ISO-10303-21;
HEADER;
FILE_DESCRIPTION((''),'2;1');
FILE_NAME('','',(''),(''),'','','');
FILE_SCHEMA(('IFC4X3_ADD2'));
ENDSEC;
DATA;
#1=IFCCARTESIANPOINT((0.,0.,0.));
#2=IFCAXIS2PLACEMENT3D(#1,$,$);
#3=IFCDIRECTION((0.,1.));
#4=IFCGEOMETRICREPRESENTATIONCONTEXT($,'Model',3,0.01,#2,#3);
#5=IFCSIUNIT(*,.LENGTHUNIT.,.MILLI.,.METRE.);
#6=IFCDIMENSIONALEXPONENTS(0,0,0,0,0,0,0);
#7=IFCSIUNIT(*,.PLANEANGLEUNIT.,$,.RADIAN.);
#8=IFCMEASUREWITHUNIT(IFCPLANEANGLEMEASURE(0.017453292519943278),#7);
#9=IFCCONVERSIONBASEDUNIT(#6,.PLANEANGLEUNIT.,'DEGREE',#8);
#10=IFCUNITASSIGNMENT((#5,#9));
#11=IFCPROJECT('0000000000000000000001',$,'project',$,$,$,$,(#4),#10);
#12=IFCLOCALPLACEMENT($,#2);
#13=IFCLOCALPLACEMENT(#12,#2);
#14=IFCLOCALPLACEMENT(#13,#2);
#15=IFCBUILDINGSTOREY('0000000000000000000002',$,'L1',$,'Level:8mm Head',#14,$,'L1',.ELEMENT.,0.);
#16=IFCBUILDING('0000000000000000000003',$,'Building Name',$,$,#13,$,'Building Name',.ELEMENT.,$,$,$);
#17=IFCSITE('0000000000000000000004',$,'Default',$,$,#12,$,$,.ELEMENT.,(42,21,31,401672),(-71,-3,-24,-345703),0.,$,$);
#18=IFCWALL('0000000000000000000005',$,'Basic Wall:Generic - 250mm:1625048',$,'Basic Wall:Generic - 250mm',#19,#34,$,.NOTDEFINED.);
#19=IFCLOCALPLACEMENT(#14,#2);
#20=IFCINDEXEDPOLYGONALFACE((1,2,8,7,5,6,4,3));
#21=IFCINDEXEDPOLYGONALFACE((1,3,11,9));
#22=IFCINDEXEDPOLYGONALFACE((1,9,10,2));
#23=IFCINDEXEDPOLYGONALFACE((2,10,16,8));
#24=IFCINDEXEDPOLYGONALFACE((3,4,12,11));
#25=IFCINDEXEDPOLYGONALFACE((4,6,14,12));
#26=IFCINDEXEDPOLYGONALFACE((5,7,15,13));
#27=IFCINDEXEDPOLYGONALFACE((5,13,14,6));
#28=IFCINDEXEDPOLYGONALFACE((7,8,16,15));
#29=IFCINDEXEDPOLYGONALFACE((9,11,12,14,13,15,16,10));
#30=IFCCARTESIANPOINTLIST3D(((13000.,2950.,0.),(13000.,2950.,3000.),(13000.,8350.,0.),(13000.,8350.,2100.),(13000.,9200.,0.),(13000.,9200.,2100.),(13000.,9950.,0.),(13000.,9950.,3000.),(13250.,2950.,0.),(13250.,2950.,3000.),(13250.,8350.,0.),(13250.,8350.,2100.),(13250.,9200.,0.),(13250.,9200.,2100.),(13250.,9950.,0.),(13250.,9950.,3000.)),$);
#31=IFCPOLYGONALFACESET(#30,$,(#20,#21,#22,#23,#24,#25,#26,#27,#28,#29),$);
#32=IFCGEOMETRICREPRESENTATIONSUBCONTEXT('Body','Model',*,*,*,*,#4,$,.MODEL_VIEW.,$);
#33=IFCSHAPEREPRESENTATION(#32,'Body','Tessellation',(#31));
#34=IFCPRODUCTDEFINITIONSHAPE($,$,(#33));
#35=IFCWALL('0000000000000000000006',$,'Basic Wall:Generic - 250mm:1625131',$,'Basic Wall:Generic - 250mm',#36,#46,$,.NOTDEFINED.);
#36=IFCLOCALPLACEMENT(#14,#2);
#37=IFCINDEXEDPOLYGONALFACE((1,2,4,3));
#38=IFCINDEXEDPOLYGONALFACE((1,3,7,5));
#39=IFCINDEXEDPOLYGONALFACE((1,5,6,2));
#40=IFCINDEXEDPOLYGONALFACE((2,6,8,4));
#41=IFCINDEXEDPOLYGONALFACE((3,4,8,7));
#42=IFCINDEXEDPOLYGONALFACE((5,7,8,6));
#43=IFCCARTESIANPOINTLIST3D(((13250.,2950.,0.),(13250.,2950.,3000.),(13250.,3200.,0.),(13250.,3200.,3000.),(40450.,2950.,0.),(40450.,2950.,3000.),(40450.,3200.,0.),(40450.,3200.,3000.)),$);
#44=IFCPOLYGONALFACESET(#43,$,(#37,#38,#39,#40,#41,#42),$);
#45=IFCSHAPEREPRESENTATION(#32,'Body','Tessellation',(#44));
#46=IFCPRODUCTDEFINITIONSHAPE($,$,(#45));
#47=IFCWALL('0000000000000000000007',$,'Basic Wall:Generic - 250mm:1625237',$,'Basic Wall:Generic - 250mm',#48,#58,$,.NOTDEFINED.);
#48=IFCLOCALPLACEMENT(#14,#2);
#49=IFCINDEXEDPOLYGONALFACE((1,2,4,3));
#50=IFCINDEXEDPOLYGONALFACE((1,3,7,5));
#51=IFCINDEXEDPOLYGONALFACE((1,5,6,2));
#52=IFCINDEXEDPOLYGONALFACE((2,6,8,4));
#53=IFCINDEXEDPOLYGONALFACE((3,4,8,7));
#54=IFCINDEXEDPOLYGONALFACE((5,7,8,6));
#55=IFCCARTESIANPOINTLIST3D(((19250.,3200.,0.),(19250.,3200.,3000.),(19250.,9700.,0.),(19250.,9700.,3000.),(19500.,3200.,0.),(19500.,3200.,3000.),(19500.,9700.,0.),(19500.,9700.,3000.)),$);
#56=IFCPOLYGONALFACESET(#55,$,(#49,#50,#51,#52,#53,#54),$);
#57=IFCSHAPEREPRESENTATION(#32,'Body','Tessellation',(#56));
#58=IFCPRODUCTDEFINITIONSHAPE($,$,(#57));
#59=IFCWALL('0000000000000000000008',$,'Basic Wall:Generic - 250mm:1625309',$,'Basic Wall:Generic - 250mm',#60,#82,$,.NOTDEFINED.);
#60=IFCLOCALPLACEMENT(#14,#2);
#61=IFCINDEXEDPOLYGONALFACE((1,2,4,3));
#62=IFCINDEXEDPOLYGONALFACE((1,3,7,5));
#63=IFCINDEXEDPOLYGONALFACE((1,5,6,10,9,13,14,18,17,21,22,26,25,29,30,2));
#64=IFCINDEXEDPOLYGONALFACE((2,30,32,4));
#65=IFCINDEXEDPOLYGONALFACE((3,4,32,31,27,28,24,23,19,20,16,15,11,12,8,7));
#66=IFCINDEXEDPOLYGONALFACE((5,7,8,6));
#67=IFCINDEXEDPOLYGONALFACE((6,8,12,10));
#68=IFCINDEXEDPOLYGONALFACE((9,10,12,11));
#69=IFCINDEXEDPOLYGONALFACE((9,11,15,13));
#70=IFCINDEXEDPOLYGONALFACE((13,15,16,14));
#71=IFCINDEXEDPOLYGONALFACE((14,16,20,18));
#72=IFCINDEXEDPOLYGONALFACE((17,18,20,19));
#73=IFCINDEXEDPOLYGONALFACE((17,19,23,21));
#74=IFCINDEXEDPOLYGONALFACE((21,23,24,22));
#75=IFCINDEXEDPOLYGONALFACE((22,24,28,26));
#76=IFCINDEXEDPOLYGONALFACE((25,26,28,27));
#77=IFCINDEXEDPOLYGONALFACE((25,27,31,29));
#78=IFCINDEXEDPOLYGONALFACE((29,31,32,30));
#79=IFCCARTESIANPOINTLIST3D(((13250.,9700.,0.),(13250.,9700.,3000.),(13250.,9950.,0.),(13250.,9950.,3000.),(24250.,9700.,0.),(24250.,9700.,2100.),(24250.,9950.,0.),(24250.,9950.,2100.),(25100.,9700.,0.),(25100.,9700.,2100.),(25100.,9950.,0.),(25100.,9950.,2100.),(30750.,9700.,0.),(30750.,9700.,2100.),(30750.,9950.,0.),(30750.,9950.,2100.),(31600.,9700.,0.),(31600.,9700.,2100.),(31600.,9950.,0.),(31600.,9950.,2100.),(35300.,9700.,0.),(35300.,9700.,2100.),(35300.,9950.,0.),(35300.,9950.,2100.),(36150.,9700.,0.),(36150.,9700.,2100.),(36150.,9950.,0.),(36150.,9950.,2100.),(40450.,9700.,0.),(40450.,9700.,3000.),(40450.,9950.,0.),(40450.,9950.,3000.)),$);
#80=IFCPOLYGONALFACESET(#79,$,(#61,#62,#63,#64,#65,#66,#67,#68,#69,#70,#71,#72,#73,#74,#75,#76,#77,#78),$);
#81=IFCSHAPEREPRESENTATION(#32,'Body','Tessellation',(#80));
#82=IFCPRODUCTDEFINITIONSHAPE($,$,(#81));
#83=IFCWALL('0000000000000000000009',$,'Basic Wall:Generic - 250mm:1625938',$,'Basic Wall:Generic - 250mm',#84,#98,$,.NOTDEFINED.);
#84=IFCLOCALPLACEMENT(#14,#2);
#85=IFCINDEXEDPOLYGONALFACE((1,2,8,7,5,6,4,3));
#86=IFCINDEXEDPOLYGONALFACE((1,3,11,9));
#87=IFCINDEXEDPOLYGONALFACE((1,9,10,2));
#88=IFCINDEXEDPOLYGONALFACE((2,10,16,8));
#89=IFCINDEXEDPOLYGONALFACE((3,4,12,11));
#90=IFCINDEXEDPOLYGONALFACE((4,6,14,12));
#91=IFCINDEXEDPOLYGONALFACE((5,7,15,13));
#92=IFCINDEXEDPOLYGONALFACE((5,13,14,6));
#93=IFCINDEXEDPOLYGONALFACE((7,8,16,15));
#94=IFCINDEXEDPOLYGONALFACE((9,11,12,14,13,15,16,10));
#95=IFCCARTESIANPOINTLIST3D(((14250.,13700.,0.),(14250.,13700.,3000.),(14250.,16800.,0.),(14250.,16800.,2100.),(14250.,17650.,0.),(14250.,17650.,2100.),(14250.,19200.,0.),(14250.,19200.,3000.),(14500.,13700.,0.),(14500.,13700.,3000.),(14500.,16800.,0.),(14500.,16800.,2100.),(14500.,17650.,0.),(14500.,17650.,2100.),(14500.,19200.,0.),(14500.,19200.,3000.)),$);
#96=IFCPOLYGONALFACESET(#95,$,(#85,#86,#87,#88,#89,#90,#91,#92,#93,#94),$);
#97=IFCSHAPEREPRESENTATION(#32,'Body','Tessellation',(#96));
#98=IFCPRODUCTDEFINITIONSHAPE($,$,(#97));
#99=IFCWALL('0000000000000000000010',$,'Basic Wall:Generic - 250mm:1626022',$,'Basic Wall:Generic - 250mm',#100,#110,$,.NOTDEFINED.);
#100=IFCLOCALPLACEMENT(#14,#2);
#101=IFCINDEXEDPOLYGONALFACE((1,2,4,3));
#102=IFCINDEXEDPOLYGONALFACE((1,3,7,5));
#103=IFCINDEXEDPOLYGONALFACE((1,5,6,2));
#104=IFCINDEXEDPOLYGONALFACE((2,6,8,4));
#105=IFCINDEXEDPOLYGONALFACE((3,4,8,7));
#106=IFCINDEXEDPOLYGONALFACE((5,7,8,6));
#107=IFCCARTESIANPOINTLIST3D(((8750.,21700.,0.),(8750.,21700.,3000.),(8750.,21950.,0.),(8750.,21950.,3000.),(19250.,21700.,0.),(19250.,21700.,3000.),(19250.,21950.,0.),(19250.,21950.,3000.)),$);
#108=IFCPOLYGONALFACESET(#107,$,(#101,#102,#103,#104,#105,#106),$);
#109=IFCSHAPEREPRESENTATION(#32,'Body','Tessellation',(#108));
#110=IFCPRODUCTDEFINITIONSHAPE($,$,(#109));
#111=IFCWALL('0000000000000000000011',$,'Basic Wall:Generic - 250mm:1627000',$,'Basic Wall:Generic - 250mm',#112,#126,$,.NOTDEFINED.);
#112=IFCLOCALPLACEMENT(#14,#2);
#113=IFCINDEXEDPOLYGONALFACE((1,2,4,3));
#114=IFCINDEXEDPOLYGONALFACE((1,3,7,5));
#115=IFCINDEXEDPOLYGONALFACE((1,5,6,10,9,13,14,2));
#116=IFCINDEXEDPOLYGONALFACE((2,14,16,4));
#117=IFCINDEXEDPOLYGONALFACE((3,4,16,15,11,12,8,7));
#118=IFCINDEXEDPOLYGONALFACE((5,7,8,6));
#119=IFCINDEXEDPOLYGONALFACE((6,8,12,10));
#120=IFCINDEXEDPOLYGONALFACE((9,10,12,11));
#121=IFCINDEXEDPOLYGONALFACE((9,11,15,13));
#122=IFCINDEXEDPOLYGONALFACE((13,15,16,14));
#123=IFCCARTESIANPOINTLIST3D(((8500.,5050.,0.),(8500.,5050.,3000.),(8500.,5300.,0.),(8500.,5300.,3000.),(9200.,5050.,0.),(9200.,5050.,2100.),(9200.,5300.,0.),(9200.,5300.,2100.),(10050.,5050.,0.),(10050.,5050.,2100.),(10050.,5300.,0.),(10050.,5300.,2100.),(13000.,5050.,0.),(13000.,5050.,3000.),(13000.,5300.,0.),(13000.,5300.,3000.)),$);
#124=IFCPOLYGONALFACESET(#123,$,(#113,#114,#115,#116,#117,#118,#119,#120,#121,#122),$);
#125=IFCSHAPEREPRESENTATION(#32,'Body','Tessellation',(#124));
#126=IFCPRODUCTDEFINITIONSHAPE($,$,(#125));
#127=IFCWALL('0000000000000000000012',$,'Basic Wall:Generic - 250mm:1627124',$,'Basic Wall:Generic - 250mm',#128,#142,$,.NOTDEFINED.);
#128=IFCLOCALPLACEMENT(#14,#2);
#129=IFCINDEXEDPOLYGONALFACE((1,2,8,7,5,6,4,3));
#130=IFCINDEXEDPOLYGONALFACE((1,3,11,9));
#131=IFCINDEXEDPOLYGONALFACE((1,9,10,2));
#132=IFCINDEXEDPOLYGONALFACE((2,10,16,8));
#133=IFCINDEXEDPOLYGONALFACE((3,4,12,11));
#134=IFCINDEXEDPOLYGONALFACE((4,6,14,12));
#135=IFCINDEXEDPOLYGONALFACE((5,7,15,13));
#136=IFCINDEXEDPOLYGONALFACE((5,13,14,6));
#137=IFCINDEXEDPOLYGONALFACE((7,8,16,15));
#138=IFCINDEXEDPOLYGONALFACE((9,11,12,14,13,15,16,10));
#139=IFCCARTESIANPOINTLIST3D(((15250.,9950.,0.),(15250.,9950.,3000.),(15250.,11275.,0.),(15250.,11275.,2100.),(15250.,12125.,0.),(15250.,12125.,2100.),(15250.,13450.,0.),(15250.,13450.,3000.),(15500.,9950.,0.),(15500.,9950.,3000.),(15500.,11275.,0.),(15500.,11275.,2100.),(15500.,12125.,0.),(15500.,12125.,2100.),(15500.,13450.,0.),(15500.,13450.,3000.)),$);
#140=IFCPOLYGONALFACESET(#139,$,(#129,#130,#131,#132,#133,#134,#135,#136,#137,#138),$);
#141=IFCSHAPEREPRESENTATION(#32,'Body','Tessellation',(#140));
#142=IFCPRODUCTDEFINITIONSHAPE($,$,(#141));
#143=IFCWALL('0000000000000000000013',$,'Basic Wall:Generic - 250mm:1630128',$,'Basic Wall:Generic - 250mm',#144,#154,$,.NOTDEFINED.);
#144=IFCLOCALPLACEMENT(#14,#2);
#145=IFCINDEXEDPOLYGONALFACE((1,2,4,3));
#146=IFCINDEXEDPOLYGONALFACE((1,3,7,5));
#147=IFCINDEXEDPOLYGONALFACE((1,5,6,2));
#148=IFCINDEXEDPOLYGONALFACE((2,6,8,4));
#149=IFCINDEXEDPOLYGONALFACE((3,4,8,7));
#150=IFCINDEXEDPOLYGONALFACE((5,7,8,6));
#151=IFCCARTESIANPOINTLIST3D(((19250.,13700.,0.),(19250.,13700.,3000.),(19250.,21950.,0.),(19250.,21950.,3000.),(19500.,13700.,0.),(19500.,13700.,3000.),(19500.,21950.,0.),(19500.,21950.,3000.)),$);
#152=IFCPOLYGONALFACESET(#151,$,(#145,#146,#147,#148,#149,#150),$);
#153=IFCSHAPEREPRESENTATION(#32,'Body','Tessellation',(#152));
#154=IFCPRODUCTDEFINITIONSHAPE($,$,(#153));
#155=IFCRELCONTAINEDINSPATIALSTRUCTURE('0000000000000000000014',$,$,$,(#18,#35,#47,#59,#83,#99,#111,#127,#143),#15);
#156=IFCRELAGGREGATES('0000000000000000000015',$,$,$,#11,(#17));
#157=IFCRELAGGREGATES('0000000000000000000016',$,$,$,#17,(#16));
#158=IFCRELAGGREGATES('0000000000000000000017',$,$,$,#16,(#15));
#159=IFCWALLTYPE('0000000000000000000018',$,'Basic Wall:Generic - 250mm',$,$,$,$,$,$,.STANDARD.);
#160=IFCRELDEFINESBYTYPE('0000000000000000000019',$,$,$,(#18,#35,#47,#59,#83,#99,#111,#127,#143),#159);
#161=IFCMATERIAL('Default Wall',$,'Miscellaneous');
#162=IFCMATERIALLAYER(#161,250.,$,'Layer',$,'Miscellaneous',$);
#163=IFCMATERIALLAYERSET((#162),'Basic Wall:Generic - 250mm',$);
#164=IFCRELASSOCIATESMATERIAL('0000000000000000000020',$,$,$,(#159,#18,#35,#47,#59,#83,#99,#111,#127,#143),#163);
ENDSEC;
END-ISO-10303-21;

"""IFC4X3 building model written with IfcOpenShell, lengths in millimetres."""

from ifc_helpers import new_model, entity, si_unit, converted_unit, direction, frame, frame_2d, origin, place, context, subcontext, project, spatial, rectangle, extrude, material, layer, layer_set, type_object, element, save


model = new_model("IFC4X3")

# Units and contexts
model_context = context("Model", 3, precision=0.01, world=origin(), true_north=direction((0.0, 1.0)))
body_context = subcontext(model_context, "Body", "Model", "MODEL_VIEW")
ifc_project = project(units=[si_unit("LENGTHUNIT", "METRE", prefix="MILLI"), converted_unit("PLANEANGLEUNIT", "DEGREE", entity("IfcPlaneAngleMeasure", 0.017453292519943278), si_unit("PLANEANGLEUNIT", "RADIAN"), dimensions=[0, 0, 0, 0, 0, 0, 0])], contexts=[model_context])

# Site, building, storey
site_placement = place(None, origin())
site = spatial("IfcSite", under=ifc_project, at=site_placement, Name="Default", CompositionType="ELEMENT", RefLatitude=(42, 21, 31, 401672), RefLongitude=(-71, -3, -24, -345703), RefElevation=0.0)
building_placement = place(site_placement, origin())
building = spatial("IfcBuilding", under=site, at=building_placement, Name="Building Name", LongName="Building Name", CompositionType="ELEMENT")
storey_placement = place(building_placement, origin())
storey = spatial("IfcBuildingStorey", under=building, at=storey_placement, Name="L1", ObjectType="Level:8mm Head", LongName="L1", CompositionType="ELEMENT", Elevation=0.0)

# Wall, opening
ifc_material = material(Name="Default Wall", Category="Miscellaneous")
ifc_layer = layer(ifc_material, 250.0, Name="Layer", Category="Miscellaneous")
ifc_layer_set = layer_set([ifc_layer], Name="Basic Wall:Generic - 250mm")
wall_type = type_object("IfcWallType", Name="Basic Wall:Generic - 250mm", PredefinedType="STANDARD", material=ifc_layer_set)
wall_1_placement = place(storey_placement, frame((13125.0, 9950.0, 0.0), z_axis=(0.0, 0.0, 1.0), x_axis=(0.0, -1.0, 0.0)))
wall_1 = element("IfcWall", 1, at=wall_1_placement, inside=storey, type_object=wall_type, material=ifc_layer_set, Name="Basic Wall:Generic - 250mm:1625048", ObjectType="Basic Wall:Generic - 250mm", PredefinedType="NOTDEFINED", context=body_context, shape_type="SweptSolid", body=[
    extrude(rectangle(XDim=7000.0, YDim=250.0, at=frame_2d((3500.0, 0.0), x_axis=(-1.0, 0.0))), origin(), (0.0, 0.0, 1.0), 3000.0),
])
opening_1_placement = place(wall_1_placement, frame((750.0, -125.0, 0.0)))
element("IfcOpeningElement", 2, at=opening_1_placement, cuts=wall_1, PredefinedType="OPENING", context=body_context, shape_type="SweptSolid", body=[
    extrude(rectangle(XDim=2100.0, YDim=850.0, at=frame_2d((1050.0, 425.0), x_axis=(1.0, 0.0))), frame((0.0, 0.0, 0.0), z_axis=(0.0, 1.0, 0.0), x_axis=(0.0, 0.0, 1.0)), (0.0, 0.0, 1.0), 250.0),
])

# Walls
wall_2_placement = place(storey_placement, frame((13250.0, 3075.0, 0.0)))
element("IfcWall", 3, at=wall_2_placement, inside=storey, type_object=wall_type, material=ifc_layer_set, Name="Basic Wall:Generic - 250mm:1625131", ObjectType="Basic Wall:Generic - 250mm", PredefinedType="NOTDEFINED", context=body_context, shape_type="SweptSolid", body=[
    extrude(rectangle(XDim=27200.0, YDim=250.0, at=frame_2d((13600.0, 0.0), x_axis=(-1.0, 0.0))), origin(), (0.0, 0.0, 1.0), 3000.0),
])
wall_3_placement = place(storey_placement, frame((19375.0, 3200.0, 0.0), z_axis=(0.0, 0.0, 1.0), x_axis=(0.0, 1.0, 0.0)))
element("IfcWall", 4, at=wall_3_placement, inside=storey, type_object=wall_type, material=ifc_layer_set, Name="Basic Wall:Generic - 250mm:1625237", ObjectType="Basic Wall:Generic - 250mm", PredefinedType="NOTDEFINED", context=body_context, shape_type="SweptSolid", body=[
    extrude(rectangle(XDim=6500.0, YDim=250.0, at=frame_2d((3250.0, 0.0), x_axis=(-1.0, 0.0))), origin(), (0.0, 0.0, 1.0), 3000.0),
])

# Wall, openings
wall_4_placement = place(storey_placement, frame((40450.0, 9825.0, 0.0), z_axis=(0.0, 0.0, 1.0), x_axis=(-1.0, 0.0, 0.0)))
wall_4 = element("IfcWall", 5, at=wall_4_placement, inside=storey, type_object=wall_type, material=ifc_layer_set, Name="Basic Wall:Generic - 250mm:1625309", ObjectType="Basic Wall:Generic - 250mm", PredefinedType="NOTDEFINED", context=body_context, shape_type="SweptSolid", body=[
    extrude(rectangle(XDim=27200.0, YDim=250.0, at=frame_2d((13600.0, 0.0), x_axis=(1.0, 0.0))), origin(), (0.0, 0.0, 1.0), 3000.0),
])
opening_2_placement = place(wall_4_placement, frame((15350.0, -125.0, 0.0)))
element("IfcOpeningElement", 6, at=opening_2_placement, cuts=wall_4, PredefinedType="OPENING", context=body_context, shape_type="SweptSolid", body=[
    extrude(rectangle(XDim=2100.0, YDim=850.0, at=frame_2d((1050.0, 425.0), x_axis=(1.0, 0.0))), frame((0.0, 0.0, 0.0), z_axis=(0.0, 1.0, 0.0), x_axis=(0.0, 0.0, 1.0)), (0.0, 0.0, 1.0), 250.0),
])
opening_3_placement = place(wall_4_placement, frame((8850.0, -125.0, 0.0)))
element("IfcOpeningElement", 7, at=opening_3_placement, cuts=wall_4, PredefinedType="OPENING", context=body_context, shape_type="SweptSolid", body=[
    extrude(rectangle(XDim=2100.0, YDim=850.0, at=frame_2d((1050.0, 425.0), x_axis=(1.0, 0.0))), frame((0.0, 0.0, 0.0), z_axis=(0.0, 1.0, 0.0), x_axis=(0.0, 0.0, 1.0)), (0.0, 0.0, 1.0), 250.0),
])
opening_4_placement = place(wall_4_placement, frame((4300.0, -125.0, 0.0)))
element("IfcOpeningElement", 8, at=opening_4_placement, cuts=wall_4, PredefinedType="OPENING", context=body_context, shape_type="SweptSolid", body=[
    extrude(rectangle(XDim=2100.0, YDim=850.0, at=frame_2d((1050.0, 425.0), x_axis=(1.0, 0.0))), frame((0.0, 0.0, 0.0), z_axis=(0.0, 1.0, 0.0), x_axis=(0.0, 0.0, 1.0)), (0.0, 0.0, 1.0), 250.0),
])

# Wall, opening
wall_5_placement = place(storey_placement, frame((14375.0, 13700.0, 0.0), z_axis=(0.0, 0.0, 1.0), x_axis=(0.0, 1.0, 0.0)))
wall_5 = element("IfcWall", 9, at=wall_5_placement, inside=storey, type_object=wall_type, material=ifc_layer_set, Name="Basic Wall:Generic - 250mm:1625938", ObjectType="Basic Wall:Generic - 250mm", PredefinedType="NOTDEFINED", context=body_context, shape_type="SweptSolid", body=[
    extrude(rectangle(XDim=5500.0, YDim=250.0, at=frame_2d((2750.0, 0.0), x_axis=(1.0, 0.0))), origin(), (0.0, 0.0, 1.0), 3000.0),
])
opening_5_placement = place(wall_5_placement, frame((3950.0, 125.0, 0.0)))
element("IfcOpeningElement", 10, at=opening_5_placement, cuts=wall_5, PredefinedType="OPENING", context=body_context, shape_type="SweptSolid", body=[
    extrude(rectangle(XDim=2100.0, YDim=850.0, at=frame_2d((1050.0, 425.0), x_axis=(1.0, 0.0))), frame((0.0, 0.0, 0.0), z_axis=(0.0, -1.0, 0.0), x_axis=(0.0, 0.0, 1.0)), (0.0, 0.0, 1.0), 250.0),
])

# Wall
wall_6_placement = place(storey_placement, frame((19250.0, 21825.0, 0.0), z_axis=(0.0, 0.0, 1.0), x_axis=(-1.0, 0.0, 0.0)))
element("IfcWall", 11, at=wall_6_placement, inside=storey, type_object=wall_type, material=ifc_layer_set, Name="Basic Wall:Generic - 250mm:1626022", ObjectType="Basic Wall:Generic - 250mm", PredefinedType="NOTDEFINED", context=body_context, shape_type="SweptSolid", body=[
    extrude(rectangle(XDim=10500.0, YDim=250.0, at=frame_2d((5250.0, 0.0), x_axis=(-1.0, 0.0))), origin(), (0.0, 0.0, 1.0), 3000.0),
])

# Walls, openings
wall_7_placement = place(storey_placement, frame((13000.0, 5175.0, 0.0), z_axis=(0.0, 0.0, 1.0), x_axis=(-1.0, 0.0, 0.0)))
wall_7 = element("IfcWall", 12, at=wall_7_placement, inside=storey, type_object=wall_type, material=ifc_layer_set, Name="Basic Wall:Generic - 250mm:1627000", ObjectType="Basic Wall:Generic - 250mm", PredefinedType="NOTDEFINED", context=body_context, shape_type="SweptSolid", body=[
    extrude(rectangle(XDim=4500.0, YDim=250.0, at=frame_2d((2250.0, 0.0), x_axis=(-1.0, 0.0))), origin(), (0.0, 0.0, 1.0), 3000.0),
])
opening_6_placement = place(wall_7_placement, frame((3800.0, 125.0, 0.0)))
element("IfcOpeningElement", 13, at=opening_6_placement, cuts=wall_7, PredefinedType="OPENING", context=body_context, shape_type="SweptSolid", body=[
    extrude(rectangle(XDim=2100.0, YDim=850.0, at=frame_2d((1050.0, 425.0), x_axis=(1.0, 0.0))), frame((0.0, 0.0, 0.0), z_axis=(0.0, -1.0, 0.0), x_axis=(0.0, 0.0, 1.0)), (0.0, 0.0, 1.0), 250.0),
])
wall_8_placement = place(storey_placement, frame((15375.0, 13450.0, 0.0), z_axis=(0.0, 0.0, 1.0), x_axis=(0.0, -1.0, 0.0)))
wall_8 = element("IfcWall", 14, at=wall_8_placement, inside=storey, type_object=wall_type, material=ifc_layer_set, Name="Basic Wall:Generic - 250mm:1627124", ObjectType="Basic Wall:Generic - 250mm", PredefinedType="NOTDEFINED", context=body_context, shape_type="SweptSolid", body=[
    extrude(rectangle(XDim=3500.0, YDim=250.0, at=frame_2d((1750.0, 0.0), x_axis=(1.0, 0.0))), origin(), (0.0, 0.0, 1.0), 3000.0),
])
opening_7_placement = place(wall_8_placement, frame((1325.0, -125.0, 0.0)))
element("IfcOpeningElement", 15, at=opening_7_placement, cuts=wall_8, PredefinedType="OPENING", context=body_context, shape_type="SweptSolid", body=[
    extrude(rectangle(XDim=2100.0, YDim=850.0, at=frame_2d((1050.0, 425.0), x_axis=(1.0, 0.0))), frame((0.0, 0.0, 0.0), z_axis=(0.0, 1.0, 0.0), x_axis=(0.0, 0.0, 1.0)), (0.0, 0.0, 1.0), 250.0),
])

# Wall
wall_9_placement = place(storey_placement, frame((19375.0, 13700.0, 0.0), z_axis=(0.0, 0.0, 1.0), x_axis=(0.0, 1.0, 0.0)))
element("IfcWall", 16, at=wall_9_placement, inside=storey, type_object=wall_type, material=ifc_layer_set, Name="Basic Wall:Generic - 250mm:1630128", ObjectType="Basic Wall:Generic - 250mm", PredefinedType="NOTDEFINED", context=body_context, shape_type="SweptSolid", body=[
    extrude(rectangle(XDim=8250.0, YDim=250.0, at=frame_2d((4125.0, 0.0), x_axis=(-1.0, 0.0))), origin(), (0.0, 0.0, 1.0), 3000.0),
])

save(model, "model.ifc")
